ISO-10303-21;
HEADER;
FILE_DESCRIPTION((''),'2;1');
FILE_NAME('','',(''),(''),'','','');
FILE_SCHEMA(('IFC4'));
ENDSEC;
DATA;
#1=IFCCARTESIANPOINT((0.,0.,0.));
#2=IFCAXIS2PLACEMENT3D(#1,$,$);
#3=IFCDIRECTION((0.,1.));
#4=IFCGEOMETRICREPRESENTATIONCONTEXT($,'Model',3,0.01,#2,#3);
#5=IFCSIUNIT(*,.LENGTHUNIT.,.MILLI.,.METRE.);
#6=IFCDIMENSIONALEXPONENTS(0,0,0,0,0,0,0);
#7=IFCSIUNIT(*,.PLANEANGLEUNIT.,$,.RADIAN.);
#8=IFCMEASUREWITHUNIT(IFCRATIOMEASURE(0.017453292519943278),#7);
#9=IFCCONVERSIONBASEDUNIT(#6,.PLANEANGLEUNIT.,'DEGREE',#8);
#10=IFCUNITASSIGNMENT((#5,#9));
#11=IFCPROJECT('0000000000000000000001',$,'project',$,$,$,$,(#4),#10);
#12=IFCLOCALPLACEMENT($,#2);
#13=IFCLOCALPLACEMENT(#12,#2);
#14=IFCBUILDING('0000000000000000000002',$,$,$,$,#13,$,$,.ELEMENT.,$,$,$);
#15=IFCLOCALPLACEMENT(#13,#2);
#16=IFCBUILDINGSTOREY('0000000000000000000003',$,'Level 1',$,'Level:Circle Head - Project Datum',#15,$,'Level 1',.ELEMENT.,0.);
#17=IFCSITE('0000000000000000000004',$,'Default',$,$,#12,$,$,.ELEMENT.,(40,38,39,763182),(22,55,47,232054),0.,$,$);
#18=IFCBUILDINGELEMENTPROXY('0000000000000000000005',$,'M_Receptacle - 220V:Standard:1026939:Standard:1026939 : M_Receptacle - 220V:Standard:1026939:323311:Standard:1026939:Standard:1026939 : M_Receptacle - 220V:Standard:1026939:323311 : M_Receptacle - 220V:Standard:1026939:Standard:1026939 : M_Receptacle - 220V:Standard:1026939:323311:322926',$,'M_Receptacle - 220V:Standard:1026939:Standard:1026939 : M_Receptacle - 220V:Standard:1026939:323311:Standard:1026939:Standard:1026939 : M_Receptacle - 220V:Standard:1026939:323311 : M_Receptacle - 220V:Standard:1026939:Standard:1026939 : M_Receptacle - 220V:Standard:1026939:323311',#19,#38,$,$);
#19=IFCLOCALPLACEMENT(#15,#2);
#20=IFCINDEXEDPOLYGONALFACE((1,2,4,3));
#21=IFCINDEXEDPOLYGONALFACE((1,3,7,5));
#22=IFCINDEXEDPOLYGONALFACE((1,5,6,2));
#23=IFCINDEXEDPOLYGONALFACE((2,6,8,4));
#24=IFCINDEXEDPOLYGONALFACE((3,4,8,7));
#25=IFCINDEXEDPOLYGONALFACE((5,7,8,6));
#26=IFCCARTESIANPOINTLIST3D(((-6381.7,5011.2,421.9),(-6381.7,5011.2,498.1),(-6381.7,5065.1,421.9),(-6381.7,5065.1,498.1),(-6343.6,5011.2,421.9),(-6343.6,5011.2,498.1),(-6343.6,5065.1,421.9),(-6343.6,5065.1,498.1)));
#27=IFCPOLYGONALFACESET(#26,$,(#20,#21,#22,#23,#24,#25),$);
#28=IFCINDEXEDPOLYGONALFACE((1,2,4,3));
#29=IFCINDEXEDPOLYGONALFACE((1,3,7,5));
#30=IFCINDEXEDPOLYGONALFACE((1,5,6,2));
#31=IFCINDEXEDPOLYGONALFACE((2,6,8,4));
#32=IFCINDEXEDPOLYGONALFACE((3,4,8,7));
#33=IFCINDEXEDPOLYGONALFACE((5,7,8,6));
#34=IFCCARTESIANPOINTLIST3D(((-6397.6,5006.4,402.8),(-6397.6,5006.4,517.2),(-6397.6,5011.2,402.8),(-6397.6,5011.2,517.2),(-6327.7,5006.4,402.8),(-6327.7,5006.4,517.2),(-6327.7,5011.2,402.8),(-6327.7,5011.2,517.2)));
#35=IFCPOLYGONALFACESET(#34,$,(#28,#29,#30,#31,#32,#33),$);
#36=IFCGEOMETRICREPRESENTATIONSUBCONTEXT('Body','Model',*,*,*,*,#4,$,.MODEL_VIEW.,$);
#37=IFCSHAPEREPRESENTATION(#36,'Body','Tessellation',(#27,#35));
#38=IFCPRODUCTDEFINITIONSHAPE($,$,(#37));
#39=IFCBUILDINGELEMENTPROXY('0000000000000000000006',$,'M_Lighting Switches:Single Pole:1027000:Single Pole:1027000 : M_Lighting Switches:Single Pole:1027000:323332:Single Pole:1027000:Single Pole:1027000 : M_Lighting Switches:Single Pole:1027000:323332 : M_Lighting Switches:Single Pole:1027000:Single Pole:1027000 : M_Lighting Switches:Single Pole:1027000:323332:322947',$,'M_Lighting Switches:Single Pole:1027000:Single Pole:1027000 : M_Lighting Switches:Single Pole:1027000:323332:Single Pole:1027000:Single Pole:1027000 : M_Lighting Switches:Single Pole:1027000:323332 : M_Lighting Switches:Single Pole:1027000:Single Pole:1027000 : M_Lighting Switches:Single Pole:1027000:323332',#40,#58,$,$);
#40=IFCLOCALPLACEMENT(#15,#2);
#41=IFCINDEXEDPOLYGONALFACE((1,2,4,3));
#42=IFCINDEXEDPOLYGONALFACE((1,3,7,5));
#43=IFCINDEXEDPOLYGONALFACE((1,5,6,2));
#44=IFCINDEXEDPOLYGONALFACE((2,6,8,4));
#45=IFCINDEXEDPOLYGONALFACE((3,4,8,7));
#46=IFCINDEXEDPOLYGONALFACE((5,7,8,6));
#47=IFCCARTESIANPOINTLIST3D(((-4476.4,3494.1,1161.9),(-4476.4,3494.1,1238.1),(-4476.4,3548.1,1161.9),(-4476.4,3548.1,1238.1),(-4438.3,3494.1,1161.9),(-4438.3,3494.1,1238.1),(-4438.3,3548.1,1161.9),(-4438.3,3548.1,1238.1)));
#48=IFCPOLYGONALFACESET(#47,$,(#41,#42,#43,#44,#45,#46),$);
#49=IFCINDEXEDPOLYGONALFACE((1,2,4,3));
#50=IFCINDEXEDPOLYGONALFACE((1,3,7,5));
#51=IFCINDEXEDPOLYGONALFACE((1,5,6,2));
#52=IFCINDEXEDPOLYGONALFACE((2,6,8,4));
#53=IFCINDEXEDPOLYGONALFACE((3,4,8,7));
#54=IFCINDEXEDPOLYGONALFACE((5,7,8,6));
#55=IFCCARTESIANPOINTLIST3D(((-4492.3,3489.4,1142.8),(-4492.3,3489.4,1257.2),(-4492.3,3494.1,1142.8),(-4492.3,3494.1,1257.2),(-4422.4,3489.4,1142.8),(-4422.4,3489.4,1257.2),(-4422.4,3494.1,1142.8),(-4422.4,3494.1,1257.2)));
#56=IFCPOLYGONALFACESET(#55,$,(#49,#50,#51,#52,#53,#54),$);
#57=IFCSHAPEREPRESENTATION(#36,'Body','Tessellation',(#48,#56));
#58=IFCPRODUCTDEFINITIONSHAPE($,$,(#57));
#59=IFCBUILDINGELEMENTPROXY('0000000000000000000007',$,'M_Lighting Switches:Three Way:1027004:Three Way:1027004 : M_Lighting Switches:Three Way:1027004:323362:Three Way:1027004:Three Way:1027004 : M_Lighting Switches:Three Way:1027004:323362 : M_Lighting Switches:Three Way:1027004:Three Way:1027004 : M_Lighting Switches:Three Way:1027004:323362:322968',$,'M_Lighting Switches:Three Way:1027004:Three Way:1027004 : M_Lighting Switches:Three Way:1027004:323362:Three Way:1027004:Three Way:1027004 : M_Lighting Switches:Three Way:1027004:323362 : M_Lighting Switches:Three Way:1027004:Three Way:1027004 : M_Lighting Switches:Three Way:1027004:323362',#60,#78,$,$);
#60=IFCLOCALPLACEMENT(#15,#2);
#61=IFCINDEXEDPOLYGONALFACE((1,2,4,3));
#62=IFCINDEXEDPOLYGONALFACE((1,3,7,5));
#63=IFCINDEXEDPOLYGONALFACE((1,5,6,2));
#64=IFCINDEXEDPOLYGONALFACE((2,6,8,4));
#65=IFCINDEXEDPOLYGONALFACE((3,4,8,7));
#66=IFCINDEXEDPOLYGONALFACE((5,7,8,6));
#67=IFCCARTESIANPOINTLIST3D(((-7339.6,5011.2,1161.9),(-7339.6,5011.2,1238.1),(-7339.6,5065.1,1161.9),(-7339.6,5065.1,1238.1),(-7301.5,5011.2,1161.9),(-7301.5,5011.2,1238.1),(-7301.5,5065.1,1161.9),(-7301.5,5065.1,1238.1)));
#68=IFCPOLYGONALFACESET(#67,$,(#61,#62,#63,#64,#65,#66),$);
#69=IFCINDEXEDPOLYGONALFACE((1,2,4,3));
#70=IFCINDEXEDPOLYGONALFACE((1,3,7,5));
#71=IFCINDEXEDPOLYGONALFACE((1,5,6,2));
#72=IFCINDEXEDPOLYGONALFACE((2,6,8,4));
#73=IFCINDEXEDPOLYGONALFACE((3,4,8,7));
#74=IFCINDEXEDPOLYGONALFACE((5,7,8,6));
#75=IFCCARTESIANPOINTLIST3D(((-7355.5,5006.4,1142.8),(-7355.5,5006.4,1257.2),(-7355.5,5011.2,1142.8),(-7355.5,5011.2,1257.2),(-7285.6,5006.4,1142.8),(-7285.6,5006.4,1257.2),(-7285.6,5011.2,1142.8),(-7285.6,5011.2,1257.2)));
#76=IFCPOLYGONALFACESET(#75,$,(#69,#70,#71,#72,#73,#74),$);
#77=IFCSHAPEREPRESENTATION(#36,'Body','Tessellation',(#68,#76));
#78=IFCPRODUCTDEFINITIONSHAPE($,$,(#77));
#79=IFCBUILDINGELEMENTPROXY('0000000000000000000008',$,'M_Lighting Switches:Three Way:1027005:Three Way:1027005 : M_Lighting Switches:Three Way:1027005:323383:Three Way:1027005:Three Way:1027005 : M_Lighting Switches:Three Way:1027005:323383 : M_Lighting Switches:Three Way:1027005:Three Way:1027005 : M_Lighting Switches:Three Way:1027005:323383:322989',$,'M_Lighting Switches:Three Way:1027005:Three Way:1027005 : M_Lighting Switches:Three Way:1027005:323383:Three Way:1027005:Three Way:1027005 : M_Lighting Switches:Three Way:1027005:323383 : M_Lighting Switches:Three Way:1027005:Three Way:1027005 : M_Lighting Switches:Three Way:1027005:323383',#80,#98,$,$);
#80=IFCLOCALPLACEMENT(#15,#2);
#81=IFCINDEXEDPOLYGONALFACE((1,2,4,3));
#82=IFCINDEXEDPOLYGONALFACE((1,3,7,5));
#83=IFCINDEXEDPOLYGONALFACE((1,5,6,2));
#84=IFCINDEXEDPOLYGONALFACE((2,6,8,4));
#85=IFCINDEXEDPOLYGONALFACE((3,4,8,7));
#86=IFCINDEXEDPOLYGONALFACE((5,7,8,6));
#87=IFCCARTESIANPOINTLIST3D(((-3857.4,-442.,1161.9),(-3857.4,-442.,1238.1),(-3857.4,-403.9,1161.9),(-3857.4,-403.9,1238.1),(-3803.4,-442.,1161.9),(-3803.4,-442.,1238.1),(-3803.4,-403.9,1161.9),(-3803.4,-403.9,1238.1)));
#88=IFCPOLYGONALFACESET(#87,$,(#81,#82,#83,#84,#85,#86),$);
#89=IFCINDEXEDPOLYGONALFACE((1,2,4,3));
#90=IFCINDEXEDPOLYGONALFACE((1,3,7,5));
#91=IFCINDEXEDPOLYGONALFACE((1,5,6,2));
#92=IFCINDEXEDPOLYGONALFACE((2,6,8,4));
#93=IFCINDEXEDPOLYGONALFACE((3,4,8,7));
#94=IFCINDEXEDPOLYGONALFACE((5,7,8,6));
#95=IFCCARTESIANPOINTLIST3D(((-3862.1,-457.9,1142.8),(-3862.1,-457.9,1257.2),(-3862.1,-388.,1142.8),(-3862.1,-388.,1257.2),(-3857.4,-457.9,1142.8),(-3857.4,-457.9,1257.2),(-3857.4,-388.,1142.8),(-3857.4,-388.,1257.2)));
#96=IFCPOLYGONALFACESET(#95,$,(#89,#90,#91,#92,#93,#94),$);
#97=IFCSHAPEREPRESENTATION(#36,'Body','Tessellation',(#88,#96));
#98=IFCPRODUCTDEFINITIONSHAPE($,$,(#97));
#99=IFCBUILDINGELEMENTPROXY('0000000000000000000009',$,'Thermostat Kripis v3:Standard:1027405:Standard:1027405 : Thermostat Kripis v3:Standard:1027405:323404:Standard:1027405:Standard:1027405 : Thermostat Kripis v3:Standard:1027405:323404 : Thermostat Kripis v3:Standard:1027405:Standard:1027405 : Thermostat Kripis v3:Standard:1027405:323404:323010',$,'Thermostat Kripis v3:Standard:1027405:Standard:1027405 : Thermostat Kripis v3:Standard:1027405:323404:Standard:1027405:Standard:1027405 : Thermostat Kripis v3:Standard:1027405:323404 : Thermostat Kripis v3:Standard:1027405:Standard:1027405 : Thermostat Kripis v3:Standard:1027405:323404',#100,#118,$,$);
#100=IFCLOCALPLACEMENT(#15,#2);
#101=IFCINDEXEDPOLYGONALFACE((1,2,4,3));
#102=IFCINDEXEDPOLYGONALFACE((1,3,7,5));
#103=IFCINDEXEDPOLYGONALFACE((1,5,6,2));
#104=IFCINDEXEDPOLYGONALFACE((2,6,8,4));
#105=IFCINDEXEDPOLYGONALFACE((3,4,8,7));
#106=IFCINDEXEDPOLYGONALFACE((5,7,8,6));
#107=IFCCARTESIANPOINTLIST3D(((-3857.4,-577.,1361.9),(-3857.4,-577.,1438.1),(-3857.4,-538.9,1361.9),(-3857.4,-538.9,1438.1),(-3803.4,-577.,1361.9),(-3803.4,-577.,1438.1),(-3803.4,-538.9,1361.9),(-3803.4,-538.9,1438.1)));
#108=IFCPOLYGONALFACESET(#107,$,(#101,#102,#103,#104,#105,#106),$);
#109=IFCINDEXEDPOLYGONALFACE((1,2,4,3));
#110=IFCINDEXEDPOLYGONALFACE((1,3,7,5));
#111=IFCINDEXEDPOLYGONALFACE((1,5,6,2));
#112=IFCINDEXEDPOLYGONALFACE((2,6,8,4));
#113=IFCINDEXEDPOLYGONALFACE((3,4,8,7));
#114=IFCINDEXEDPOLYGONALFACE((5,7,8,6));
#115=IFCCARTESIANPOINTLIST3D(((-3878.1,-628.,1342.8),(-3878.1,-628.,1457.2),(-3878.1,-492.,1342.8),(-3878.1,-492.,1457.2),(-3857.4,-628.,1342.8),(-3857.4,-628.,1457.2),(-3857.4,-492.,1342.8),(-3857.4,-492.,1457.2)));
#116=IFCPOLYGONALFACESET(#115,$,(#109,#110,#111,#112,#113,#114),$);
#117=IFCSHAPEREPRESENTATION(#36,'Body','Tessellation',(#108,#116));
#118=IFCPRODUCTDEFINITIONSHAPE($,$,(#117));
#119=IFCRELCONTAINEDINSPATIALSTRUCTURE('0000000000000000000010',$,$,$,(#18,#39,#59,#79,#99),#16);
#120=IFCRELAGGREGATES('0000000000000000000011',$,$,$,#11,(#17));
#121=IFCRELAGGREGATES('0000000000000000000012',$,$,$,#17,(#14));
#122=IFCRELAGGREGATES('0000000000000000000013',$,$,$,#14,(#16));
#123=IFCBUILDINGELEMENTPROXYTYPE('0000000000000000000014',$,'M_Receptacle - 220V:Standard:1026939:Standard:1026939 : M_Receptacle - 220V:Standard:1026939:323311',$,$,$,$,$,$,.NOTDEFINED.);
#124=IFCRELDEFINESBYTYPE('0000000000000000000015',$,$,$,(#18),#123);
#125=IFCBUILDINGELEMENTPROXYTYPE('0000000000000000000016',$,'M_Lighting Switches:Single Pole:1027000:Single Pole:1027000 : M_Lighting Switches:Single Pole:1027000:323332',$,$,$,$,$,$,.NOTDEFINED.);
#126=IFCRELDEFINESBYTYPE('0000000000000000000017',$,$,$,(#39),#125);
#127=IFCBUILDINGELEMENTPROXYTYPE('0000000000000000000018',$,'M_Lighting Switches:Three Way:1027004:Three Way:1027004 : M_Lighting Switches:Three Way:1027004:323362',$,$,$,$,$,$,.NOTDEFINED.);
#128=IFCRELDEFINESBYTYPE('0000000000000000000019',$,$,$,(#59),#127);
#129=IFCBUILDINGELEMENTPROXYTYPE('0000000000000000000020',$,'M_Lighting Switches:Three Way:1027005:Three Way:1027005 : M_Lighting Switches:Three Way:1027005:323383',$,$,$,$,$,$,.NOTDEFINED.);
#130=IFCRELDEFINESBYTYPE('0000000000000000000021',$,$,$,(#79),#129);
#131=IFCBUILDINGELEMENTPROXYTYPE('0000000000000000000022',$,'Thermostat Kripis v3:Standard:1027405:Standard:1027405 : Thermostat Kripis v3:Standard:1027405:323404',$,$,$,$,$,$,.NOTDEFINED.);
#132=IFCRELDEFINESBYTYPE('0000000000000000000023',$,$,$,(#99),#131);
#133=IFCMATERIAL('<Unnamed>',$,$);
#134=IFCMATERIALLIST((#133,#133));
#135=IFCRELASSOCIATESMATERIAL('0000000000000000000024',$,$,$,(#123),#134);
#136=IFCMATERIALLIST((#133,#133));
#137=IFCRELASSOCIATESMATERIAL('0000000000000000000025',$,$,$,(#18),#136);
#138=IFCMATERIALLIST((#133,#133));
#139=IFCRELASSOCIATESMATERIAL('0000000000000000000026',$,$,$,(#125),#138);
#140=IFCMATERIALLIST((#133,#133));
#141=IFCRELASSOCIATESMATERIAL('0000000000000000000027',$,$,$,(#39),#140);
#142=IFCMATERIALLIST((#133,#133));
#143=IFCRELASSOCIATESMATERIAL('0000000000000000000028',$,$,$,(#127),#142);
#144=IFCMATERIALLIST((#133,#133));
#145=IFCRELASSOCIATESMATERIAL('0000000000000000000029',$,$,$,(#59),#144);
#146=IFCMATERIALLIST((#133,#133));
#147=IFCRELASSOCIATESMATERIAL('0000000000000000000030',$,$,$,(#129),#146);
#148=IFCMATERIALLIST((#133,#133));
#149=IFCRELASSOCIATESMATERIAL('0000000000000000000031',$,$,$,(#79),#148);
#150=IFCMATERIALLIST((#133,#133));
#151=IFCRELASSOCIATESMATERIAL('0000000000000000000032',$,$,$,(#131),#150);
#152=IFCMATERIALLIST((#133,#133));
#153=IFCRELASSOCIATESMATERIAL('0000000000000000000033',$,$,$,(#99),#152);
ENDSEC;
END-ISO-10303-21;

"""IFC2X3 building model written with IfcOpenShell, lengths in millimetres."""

from ifc_helpers import new_model, entity, si_unit, converted_unit, direction, frame, frame_2d, origin, origin_2d_with_axis, place, context, subcontext, project, spatial, rectangle, extrude, source, transform, mapped, material, material_list, type_object, type_shapes, element, save


model = new_model("IFC2X3")

# Units and contexts
model_context = context("Model", 3, precision=0.01, world=origin(), true_north=direction((0.0, 1.0)))
body_context = subcontext(model_context, "Body", "Model", "MODEL_VIEW")
ifc_project = project(units=[si_unit("LENGTHUNIT", "METRE", prefix="MILLI"), converted_unit("PLANEANGLEUNIT", "DEGREE", entity("IfcRatioMeasure", 0.017453292519943278), si_unit("PLANEANGLEUNIT", "RADIAN"), dimensions=[0, 0, 0, 0, 0, 0, 0])], contexts=[model_context])

# Site, building, storey
site_placement = place(None, origin())
site = spatial("IfcSite", under=ifc_project, at=site_placement, Name="Default", CompositionType="ELEMENT", RefLatitude=(40, 38, 39, 763182), RefLongitude=(22, 55, 47, 232054), RefElevation=0.0)
building_placement = place(site_placement, origin())
building = spatial("IfcBuilding", under=site, at=building_placement, CompositionType="ELEMENT")
storey_placement = place(building_placement, origin())
storey = spatial("IfcBuildingStorey", under=building, at=storey_placement, Name="Level 1", ObjectType="Level:Circle Head - Project Datum", LongName="Level 1", CompositionType="ELEMENT", Elevation=0.0)

# Shared definitions
ifc_material_1 = material(Name="<Unnamed>")

# Building element proxies
ifc_material_list_1 = material_list([ifc_material_1, ifc_material_1])
ifc_material_list_2 = material_list([ifc_material_1, ifc_material_1])
building_element_proxy_type_1 = type_object("IfcBuildingElementProxyType", Name="M_Receptacle - 220V:Standard:1026939:Standard:1026939 : M_Receptacle - 220V:Standard:1026939:323311", PredefinedType="NOTDEFINED", material=ifc_material_list_2)
shared_shape_1 = source(origin(), body_context, "Body", "SweptSolid", [
    extrude(rectangle(XDim=38.1, YDim=54.0, at=origin_2d_with_axis()), frame((-6362.6, 5038.1, 421.9), z_axis=(0.0, 0.0, 1.0), x_axis=(-1.0, 0.0, 0.0)), (0.0, 0.0, 1.0), 76.2),
    extrude(rectangle(XDim=69.8, YDim=4.8, at=frame_2d((0.0, 0.0), x_axis=(1.0, 0.0))), frame((-6362.6, 5008.8, 402.8), z_axis=(0.0, 0.0, 1.0), x_axis=(-1.0, 0.0, 0.0)), (0.0, 0.0, 1.0), 114.3),
])
type_shapes(building_element_proxy_type_1, [shared_shape_1])
proxy_1_placement = place(storey_placement, origin())
element("IfcBuildingElementProxy", 1, at=proxy_1_placement, inside=storey, type_object=building_element_proxy_type_1, material=ifc_material_list_1, Name="M_Receptacle - 220V:Standard:1026939:Standard:1026939 : M_Receptacle - 220V:Standard:1026939:323311:Standard:1026939:Standard:1026939 : M_Receptacle - 220V:Standard:1026939:323311 : M_Receptacle - 220V:Standard:1026939:Standard:1026939 : M_Receptacle - 220V:Standard:1026939:323311:322926", ObjectType="M_Receptacle - 220V:Standard:1026939:Standard:1026939 : M_Receptacle - 220V:Standard:1026939:323311:Standard:1026939:Standard:1026939 : M_Receptacle - 220V:Standard:1026939:323311 : M_Receptacle - 220V:Standard:1026939:Standard:1026939 : M_Receptacle - 220V:Standard:1026939:323311", context=body_context, shape_type="MappedRepresentation", body=[
    mapped(shared_shape_1, transform((0.0, 0.0, 0.0), scale=1.0)),
])
ifc_material_list_3 = material_list([ifc_material_1, ifc_material_1])
ifc_material_list_4 = material_list([ifc_material_1, ifc_material_1])
building_element_proxy_type_2 = type_object("IfcBuildingElementProxyType", Name="M_Lighting Switches:Single Pole:1027000:Single Pole:1027000 : M_Lighting Switches:Single Pole:1027000:323332", PredefinedType="NOTDEFINED", material=ifc_material_list_4)
shared_shape_2 = source(origin(), body_context, "Body", "SweptSolid", [
    extrude(rectangle(XDim=38.1, YDim=54.0, at=origin_2d_with_axis()), frame((-4457.4, 3521.1, 1161.9), z_axis=(0.0, 0.0, 1.0), x_axis=(-1.0, 0.0, 0.0)), (0.0, 0.0, 1.0), 76.2),
    extrude(rectangle(XDim=69.8, YDim=4.8, at=origin_2d_with_axis()), frame((-4457.4, 3491.7, 1142.8), z_axis=(0.0, 0.0, 1.0), x_axis=(-1.0, 0.0, 0.0)), (0.0, 0.0, 1.0), 114.3),
])
type_shapes(building_element_proxy_type_2, [shared_shape_2])
proxy_2_placement = place(storey_placement, origin())
element("IfcBuildingElementProxy", 2, at=proxy_2_placement, inside=storey, type_object=building_element_proxy_type_2, material=ifc_material_list_3, Name="M_Lighting Switches:Single Pole:1027000:Single Pole:1027000 : M_Lighting Switches:Single Pole:1027000:323332:Single Pole:1027000:Single Pole:1027000 : M_Lighting Switches:Single Pole:1027000:323332 : M_Lighting Switches:Single Pole:1027000:Single Pole:1027000 : M_Lighting Switches:Single Pole:1027000:323332:322947", ObjectType="M_Lighting Switches:Single Pole:1027000:Single Pole:1027000 : M_Lighting Switches:Single Pole:1027000:323332:Single Pole:1027000:Single Pole:1027000 : M_Lighting Switches:Single Pole:1027000:323332 : M_Lighting Switches:Single Pole:1027000:Single Pole:1027000 : M_Lighting Switches:Single Pole:1027000:323332", context=body_context, shape_type="MappedRepresentation", body=[
    mapped(shared_shape_2, transform((0.0, 0.0, 0.0), scale=1.0)),
])
ifc_material_list_5 = material_list([ifc_material_1, ifc_material_1])
ifc_material_list_6 = material_list([ifc_material_1, ifc_material_1])
building_element_proxy_type_3 = type_object("IfcBuildingElementProxyType", Name="M_Lighting Switches:Three Way:1027004:Three Way:1027004 : M_Lighting Switches:Three Way:1027004:323362", PredefinedType="NOTDEFINED", material=ifc_material_list_6)
shared_shape_3 = source(origin(), body_context, "Body", "SweptSolid", [
    extrude(rectangle(XDim=38.1, YDim=54.0, at=origin_2d_with_axis()), frame((-7320.5, 5038.1, 1161.9), z_axis=(0.0, 0.0, 1.0), x_axis=(-1.0, 0.0, 0.0)), (0.0, 0.0, 1.0), 76.2),
    extrude(rectangle(XDim=69.8, YDim=4.8, at=frame_2d((0.0, 0.0), x_axis=(1.0, 0.0))), frame((-7320.5, 5008.8, 1142.8), z_axis=(0.0, 0.0, 1.0), x_axis=(-1.0, 0.0, 0.0)), (0.0, 0.0, 1.0), 114.3),
])
type_shapes(building_element_proxy_type_3, [shared_shape_3])
proxy_3_placement = place(storey_placement, origin())
element("IfcBuildingElementProxy", 3, at=proxy_3_placement, inside=storey, type_object=building_element_proxy_type_3, material=ifc_material_list_5, Name="M_Lighting Switches:Three Way:1027004:Three Way:1027004 : M_Lighting Switches:Three Way:1027004:323362:Three Way:1027004:Three Way:1027004 : M_Lighting Switches:Three Way:1027004:323362 : M_Lighting Switches:Three Way:1027004:Three Way:1027004 : M_Lighting Switches:Three Way:1027004:323362:322968", ObjectType="M_Lighting Switches:Three Way:1027004:Three Way:1027004 : M_Lighting Switches:Three Way:1027004:323362:Three Way:1027004:Three Way:1027004 : M_Lighting Switches:Three Way:1027004:323362 : M_Lighting Switches:Three Way:1027004:Three Way:1027004 : M_Lighting Switches:Three Way:1027004:323362", context=body_context, shape_type="MappedRepresentation", body=[
    mapped(shared_shape_3, transform((0.0, 0.0, 0.0), scale=1.0)),
])
ifc_material_list_7 = material_list([ifc_material_1, ifc_material_1])
ifc_material_list_8 = material_list([ifc_material_1, ifc_material_1])
building_element_proxy_type_4 = type_object("IfcBuildingElementProxyType", Name="M_Lighting Switches:Three Way:1027005:Three Way:1027005 : M_Lighting Switches:Three Way:1027005:323383", PredefinedType="NOTDEFINED", material=ifc_material_list_8)
shared_shape_4 = source(origin(), body_context, "Body", "SweptSolid", [
    extrude(rectangle(XDim=38.1, YDim=54.0, at=frame_2d((0.0, 0.0), x_axis=(1.0, 0.0))), frame((-3830.4, -423.0, 1161.9), z_axis=(0.0, 0.0, 1.0), x_axis=(0.0, 1.0, 0.0)), (0.0, 0.0, 1.0), 76.2),
    extrude(rectangle(XDim=69.8, YDim=4.8, at=frame_2d((0.0, 0.0), x_axis=(1.0, 0.0))), frame((-3859.7, -423.0, 1142.8), z_axis=(0.0, 0.0, 1.0), x_axis=(0.0, 1.0, 0.0)), (0.0, 0.0, 1.0), 114.3),
])
type_shapes(building_element_proxy_type_4, [shared_shape_4])
proxy_4_placement = place(storey_placement, origin())
element("IfcBuildingElementProxy", 4, at=proxy_4_placement, inside=storey, type_object=building_element_proxy_type_4, material=ifc_material_list_7, Name="M_Lighting Switches:Three Way:1027005:Three Way:1027005 : M_Lighting Switches:Three Way:1027005:323383:Three Way:1027005:Three Way:1027005 : M_Lighting Switches:Three Way:1027005:323383 : M_Lighting Switches:Three Way:1027005:Three Way:1027005 : M_Lighting Switches:Three Way:1027005:323383:322989", ObjectType="M_Lighting Switches:Three Way:1027005:Three Way:1027005 : M_Lighting Switches:Three Way:1027005:323383:Three Way:1027005:Three Way:1027005 : M_Lighting Switches:Three Way:1027005:323383 : M_Lighting Switches:Three Way:1027005:Three Way:1027005 : M_Lighting Switches:Three Way:1027005:323383", context=body_context, shape_type="MappedRepresentation", body=[
    mapped(shared_shape_4, transform((0.0, 0.0, 0.0), scale=1.0)),
])
ifc_material_list_9 = material_list([ifc_material_1, ifc_material_1])
ifc_material_list_10 = material_list([ifc_material_1, ifc_material_1])
building_element_proxy_type_5 = type_object("IfcBuildingElementProxyType", Name="Thermostat Kripis v3:Standard:1027405:Standard:1027405 : Thermostat Kripis v3:Standard:1027405:323404", PredefinedType="NOTDEFINED", material=ifc_material_list_10)
shared_shape_5 = source(origin(), body_context, "Body", "SweptSolid", [
    extrude(rectangle(XDim=38.1, YDim=54.0, at=frame_2d((0.0, 0.0), x_axis=(1.0, 0.0))), frame((-3830.4, -557.9, 1361.9), z_axis=(0.0, 0.0, 1.0), x_axis=(0.0, 1.0, 0.0)), (0.0, 0.0, 1.0), 76.2),
    extrude(rectangle(XDim=136.0, YDim=20.7, at=frame_2d((0.0, 0.0), x_axis=(1.0, 0.0))), frame((-3867.7, -560.0, 1342.8), z_axis=(0.0, 0.0, 1.0), x_axis=(0.0, 1.0, 0.0)), (0.0, 0.0, 1.0), 114.3),
])
type_shapes(building_element_proxy_type_5, [shared_shape_5])
proxy_5_placement = place(storey_placement, origin())
element("IfcBuildingElementProxy", 5, at=proxy_5_placement, inside=storey, type_object=building_element_proxy_type_5, material=ifc_material_list_9, Name="Thermostat Kripis v3:Standard:1027405:Standard:1027405 : Thermostat Kripis v3:Standard:1027405:323404:Standard:1027405:Standard:1027405 : Thermostat Kripis v3:Standard:1027405:323404 : Thermostat Kripis v3:Standard:1027405:Standard:1027405 : Thermostat Kripis v3:Standard:1027405:323404:323010", ObjectType="Thermostat Kripis v3:Standard:1027405:Standard:1027405 : Thermostat Kripis v3:Standard:1027405:323404:Standard:1027405:Standard:1027405 : Thermostat Kripis v3:Standard:1027405:323404 : Thermostat Kripis v3:Standard:1027405:Standard:1027405 : Thermostat Kripis v3:Standard:1027405:323404", context=body_context, shape_type="MappedRepresentation", body=[
    mapped(shared_shape_5, transform((0.0, 0.0, 0.0), scale=1.0)),
])

save(model, "model.ifc")
